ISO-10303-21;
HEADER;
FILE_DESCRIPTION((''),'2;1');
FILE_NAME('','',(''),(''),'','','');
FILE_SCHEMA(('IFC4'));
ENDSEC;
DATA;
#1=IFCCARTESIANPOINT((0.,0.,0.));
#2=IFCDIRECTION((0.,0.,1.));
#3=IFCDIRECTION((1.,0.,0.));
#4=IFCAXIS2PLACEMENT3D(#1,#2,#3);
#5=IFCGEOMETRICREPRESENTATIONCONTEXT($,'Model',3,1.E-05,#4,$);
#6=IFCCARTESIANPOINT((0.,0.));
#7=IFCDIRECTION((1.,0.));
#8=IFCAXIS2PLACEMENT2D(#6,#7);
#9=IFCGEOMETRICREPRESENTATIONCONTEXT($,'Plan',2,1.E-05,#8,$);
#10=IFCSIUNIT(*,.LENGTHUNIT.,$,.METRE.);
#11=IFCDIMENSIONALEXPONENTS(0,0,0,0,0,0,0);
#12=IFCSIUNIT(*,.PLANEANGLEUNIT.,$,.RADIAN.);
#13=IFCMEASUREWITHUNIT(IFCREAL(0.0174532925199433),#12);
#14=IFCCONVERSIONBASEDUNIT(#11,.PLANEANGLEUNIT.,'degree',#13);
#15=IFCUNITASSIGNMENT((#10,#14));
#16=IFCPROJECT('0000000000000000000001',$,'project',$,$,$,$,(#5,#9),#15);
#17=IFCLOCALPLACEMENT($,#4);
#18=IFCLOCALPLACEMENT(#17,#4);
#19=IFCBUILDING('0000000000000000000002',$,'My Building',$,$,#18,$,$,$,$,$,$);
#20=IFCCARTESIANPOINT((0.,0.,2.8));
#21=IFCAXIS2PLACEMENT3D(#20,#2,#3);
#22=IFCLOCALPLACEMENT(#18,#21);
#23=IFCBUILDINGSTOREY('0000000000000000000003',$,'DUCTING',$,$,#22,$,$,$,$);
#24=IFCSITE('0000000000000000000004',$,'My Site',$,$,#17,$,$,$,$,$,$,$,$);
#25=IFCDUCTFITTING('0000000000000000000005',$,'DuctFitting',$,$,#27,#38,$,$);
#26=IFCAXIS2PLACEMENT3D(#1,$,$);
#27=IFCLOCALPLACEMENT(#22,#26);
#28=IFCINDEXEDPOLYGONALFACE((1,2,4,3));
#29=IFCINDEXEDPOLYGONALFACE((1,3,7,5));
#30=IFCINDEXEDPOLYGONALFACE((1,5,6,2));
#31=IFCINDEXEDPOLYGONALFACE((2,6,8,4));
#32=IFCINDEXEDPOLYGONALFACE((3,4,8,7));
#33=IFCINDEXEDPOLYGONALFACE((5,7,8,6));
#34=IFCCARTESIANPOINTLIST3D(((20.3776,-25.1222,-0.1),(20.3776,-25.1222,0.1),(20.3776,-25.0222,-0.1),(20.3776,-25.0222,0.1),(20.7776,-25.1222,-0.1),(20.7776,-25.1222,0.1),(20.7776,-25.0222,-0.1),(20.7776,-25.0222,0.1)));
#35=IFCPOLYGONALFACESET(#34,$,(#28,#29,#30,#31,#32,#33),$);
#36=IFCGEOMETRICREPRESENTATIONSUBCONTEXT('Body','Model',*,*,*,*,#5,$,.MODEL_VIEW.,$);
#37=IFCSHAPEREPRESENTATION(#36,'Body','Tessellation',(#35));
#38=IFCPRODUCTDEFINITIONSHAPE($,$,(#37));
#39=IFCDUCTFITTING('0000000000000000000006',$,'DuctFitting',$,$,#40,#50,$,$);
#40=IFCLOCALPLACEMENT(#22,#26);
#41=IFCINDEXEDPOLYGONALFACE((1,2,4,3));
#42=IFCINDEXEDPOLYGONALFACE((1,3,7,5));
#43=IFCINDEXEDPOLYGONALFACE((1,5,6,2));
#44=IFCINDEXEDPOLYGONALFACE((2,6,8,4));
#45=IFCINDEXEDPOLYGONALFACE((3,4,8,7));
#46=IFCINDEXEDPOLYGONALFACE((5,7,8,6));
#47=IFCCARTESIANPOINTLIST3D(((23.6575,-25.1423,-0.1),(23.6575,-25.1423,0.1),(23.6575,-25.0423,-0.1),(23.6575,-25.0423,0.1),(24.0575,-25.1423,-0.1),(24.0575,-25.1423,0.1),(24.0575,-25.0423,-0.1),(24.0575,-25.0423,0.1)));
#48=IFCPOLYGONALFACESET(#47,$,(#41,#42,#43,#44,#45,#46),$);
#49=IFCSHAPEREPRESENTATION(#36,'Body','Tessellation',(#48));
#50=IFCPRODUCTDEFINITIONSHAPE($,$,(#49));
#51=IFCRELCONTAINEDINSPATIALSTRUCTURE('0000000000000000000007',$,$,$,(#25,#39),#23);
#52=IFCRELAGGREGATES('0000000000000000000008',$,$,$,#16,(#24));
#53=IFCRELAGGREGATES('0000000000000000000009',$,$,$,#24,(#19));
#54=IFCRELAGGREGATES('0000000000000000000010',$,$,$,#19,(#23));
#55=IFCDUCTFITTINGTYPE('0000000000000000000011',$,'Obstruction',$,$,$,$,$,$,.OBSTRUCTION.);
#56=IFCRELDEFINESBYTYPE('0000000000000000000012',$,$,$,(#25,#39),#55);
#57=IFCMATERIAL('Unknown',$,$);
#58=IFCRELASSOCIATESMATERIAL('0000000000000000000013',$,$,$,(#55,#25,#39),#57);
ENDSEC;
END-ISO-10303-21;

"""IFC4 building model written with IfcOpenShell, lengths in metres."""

from ifc_helpers import new_model, entity, si_unit, converted_unit, frame, origin_with_axes, origin_2d_with_axis, place, context, subcontext, project, spatial, rectangle, extrude, material, material_profile, profile_set, profile_usage, type_object, element, save


model = new_model("IFC4")

# Units and contexts
model_context = context("Model", 3, precision=1e-05, world=origin_with_axes())
plan_context = context("Plan", 2, precision=1e-05, world=origin_2d_with_axis())
body_context = subcontext(model_context, "Body", "Model", "MODEL_VIEW")
ifc_project = project(units=[si_unit("LENGTHUNIT", "METRE"), converted_unit("PLANEANGLEUNIT", "degree", entity("IfcReal", 0.0174532925199433), si_unit("PLANEANGLEUNIT", "RADIAN"), dimensions=[0, 0, 0, 0, 0, 0, 0])], contexts=[model_context, plan_context])

# Site, building, storey
site_placement = place(None, origin_with_axes())
site = spatial("IfcSite", under=ifc_project, at=site_placement, Name="My Site")
building_placement = place(site_placement, origin_with_axes())
building = spatial("IfcBuilding", under=site, at=building_placement, Name="My Building")
storey_placement = place(building_placement, frame((0.0, 0.0, 2.8), z_axis=(0.0, 0.0, 1.0), x_axis=(1.0, 0.0, 0.0)))
storey = spatial("IfcBuildingStorey", under=building, at=storey_placement, Name="DUCTING")

# Shared definitions
ifc_material = material(Name="Unknown")

# Duct fittings
ifc_material_profile_1 = material_profile(ifc_material, rectangle(XDim=0.4, YDim=0.2))
ifc_profile_set_1 = profile_set([ifc_material_profile_1])
duct_fitting_type_1 = type_object("IfcDuctFittingType", Name="Obstruction", PredefinedType="OBSTRUCTION", material=ifc_profile_set_1)
ifc_profile_usage_1 = profile_usage(ifc_profile_set_1, cardinal=5)
duct_fitting_1_placement = place(storey_placement, frame((20.5776, -25.1222, 0.0), z_axis=(0.0, 1.0, 0.0), x_axis=(-1.0, 0.0, 0.0)))
element("IfcDuctFitting", 1, at=duct_fitting_1_placement, inside=storey, type_object=duct_fitting_type_1, material=ifc_profile_usage_1, Name="DuctFitting", context=body_context, shape_type="SweptSolid", body=[
    extrude(rectangle(XDim=0.4, YDim=0.2), origin_with_axes(), (0.0, 0.0, 1.0), 0.1),
])
ifc_profile_usage_2 = profile_usage(ifc_profile_set_1, cardinal=5)
duct_fitting_2_placement = place(storey_placement, frame((23.8575, -25.1423, 0.0), z_axis=(0.0, 1.0, 0.0), x_axis=(-1.0, 0.0, 0.0)))
element("IfcDuctFitting", 2, at=duct_fitting_2_placement, inside=storey, type_object=duct_fitting_type_1, material=ifc_profile_usage_2, Name="DuctFitting", context=body_context, shape_type="SweptSolid", body=[
    extrude(rectangle(XDim=0.4, YDim=0.2), origin_with_axes(), (0.0, 0.0, 1.0), 0.1),
])

save(model, "model.ifc")
